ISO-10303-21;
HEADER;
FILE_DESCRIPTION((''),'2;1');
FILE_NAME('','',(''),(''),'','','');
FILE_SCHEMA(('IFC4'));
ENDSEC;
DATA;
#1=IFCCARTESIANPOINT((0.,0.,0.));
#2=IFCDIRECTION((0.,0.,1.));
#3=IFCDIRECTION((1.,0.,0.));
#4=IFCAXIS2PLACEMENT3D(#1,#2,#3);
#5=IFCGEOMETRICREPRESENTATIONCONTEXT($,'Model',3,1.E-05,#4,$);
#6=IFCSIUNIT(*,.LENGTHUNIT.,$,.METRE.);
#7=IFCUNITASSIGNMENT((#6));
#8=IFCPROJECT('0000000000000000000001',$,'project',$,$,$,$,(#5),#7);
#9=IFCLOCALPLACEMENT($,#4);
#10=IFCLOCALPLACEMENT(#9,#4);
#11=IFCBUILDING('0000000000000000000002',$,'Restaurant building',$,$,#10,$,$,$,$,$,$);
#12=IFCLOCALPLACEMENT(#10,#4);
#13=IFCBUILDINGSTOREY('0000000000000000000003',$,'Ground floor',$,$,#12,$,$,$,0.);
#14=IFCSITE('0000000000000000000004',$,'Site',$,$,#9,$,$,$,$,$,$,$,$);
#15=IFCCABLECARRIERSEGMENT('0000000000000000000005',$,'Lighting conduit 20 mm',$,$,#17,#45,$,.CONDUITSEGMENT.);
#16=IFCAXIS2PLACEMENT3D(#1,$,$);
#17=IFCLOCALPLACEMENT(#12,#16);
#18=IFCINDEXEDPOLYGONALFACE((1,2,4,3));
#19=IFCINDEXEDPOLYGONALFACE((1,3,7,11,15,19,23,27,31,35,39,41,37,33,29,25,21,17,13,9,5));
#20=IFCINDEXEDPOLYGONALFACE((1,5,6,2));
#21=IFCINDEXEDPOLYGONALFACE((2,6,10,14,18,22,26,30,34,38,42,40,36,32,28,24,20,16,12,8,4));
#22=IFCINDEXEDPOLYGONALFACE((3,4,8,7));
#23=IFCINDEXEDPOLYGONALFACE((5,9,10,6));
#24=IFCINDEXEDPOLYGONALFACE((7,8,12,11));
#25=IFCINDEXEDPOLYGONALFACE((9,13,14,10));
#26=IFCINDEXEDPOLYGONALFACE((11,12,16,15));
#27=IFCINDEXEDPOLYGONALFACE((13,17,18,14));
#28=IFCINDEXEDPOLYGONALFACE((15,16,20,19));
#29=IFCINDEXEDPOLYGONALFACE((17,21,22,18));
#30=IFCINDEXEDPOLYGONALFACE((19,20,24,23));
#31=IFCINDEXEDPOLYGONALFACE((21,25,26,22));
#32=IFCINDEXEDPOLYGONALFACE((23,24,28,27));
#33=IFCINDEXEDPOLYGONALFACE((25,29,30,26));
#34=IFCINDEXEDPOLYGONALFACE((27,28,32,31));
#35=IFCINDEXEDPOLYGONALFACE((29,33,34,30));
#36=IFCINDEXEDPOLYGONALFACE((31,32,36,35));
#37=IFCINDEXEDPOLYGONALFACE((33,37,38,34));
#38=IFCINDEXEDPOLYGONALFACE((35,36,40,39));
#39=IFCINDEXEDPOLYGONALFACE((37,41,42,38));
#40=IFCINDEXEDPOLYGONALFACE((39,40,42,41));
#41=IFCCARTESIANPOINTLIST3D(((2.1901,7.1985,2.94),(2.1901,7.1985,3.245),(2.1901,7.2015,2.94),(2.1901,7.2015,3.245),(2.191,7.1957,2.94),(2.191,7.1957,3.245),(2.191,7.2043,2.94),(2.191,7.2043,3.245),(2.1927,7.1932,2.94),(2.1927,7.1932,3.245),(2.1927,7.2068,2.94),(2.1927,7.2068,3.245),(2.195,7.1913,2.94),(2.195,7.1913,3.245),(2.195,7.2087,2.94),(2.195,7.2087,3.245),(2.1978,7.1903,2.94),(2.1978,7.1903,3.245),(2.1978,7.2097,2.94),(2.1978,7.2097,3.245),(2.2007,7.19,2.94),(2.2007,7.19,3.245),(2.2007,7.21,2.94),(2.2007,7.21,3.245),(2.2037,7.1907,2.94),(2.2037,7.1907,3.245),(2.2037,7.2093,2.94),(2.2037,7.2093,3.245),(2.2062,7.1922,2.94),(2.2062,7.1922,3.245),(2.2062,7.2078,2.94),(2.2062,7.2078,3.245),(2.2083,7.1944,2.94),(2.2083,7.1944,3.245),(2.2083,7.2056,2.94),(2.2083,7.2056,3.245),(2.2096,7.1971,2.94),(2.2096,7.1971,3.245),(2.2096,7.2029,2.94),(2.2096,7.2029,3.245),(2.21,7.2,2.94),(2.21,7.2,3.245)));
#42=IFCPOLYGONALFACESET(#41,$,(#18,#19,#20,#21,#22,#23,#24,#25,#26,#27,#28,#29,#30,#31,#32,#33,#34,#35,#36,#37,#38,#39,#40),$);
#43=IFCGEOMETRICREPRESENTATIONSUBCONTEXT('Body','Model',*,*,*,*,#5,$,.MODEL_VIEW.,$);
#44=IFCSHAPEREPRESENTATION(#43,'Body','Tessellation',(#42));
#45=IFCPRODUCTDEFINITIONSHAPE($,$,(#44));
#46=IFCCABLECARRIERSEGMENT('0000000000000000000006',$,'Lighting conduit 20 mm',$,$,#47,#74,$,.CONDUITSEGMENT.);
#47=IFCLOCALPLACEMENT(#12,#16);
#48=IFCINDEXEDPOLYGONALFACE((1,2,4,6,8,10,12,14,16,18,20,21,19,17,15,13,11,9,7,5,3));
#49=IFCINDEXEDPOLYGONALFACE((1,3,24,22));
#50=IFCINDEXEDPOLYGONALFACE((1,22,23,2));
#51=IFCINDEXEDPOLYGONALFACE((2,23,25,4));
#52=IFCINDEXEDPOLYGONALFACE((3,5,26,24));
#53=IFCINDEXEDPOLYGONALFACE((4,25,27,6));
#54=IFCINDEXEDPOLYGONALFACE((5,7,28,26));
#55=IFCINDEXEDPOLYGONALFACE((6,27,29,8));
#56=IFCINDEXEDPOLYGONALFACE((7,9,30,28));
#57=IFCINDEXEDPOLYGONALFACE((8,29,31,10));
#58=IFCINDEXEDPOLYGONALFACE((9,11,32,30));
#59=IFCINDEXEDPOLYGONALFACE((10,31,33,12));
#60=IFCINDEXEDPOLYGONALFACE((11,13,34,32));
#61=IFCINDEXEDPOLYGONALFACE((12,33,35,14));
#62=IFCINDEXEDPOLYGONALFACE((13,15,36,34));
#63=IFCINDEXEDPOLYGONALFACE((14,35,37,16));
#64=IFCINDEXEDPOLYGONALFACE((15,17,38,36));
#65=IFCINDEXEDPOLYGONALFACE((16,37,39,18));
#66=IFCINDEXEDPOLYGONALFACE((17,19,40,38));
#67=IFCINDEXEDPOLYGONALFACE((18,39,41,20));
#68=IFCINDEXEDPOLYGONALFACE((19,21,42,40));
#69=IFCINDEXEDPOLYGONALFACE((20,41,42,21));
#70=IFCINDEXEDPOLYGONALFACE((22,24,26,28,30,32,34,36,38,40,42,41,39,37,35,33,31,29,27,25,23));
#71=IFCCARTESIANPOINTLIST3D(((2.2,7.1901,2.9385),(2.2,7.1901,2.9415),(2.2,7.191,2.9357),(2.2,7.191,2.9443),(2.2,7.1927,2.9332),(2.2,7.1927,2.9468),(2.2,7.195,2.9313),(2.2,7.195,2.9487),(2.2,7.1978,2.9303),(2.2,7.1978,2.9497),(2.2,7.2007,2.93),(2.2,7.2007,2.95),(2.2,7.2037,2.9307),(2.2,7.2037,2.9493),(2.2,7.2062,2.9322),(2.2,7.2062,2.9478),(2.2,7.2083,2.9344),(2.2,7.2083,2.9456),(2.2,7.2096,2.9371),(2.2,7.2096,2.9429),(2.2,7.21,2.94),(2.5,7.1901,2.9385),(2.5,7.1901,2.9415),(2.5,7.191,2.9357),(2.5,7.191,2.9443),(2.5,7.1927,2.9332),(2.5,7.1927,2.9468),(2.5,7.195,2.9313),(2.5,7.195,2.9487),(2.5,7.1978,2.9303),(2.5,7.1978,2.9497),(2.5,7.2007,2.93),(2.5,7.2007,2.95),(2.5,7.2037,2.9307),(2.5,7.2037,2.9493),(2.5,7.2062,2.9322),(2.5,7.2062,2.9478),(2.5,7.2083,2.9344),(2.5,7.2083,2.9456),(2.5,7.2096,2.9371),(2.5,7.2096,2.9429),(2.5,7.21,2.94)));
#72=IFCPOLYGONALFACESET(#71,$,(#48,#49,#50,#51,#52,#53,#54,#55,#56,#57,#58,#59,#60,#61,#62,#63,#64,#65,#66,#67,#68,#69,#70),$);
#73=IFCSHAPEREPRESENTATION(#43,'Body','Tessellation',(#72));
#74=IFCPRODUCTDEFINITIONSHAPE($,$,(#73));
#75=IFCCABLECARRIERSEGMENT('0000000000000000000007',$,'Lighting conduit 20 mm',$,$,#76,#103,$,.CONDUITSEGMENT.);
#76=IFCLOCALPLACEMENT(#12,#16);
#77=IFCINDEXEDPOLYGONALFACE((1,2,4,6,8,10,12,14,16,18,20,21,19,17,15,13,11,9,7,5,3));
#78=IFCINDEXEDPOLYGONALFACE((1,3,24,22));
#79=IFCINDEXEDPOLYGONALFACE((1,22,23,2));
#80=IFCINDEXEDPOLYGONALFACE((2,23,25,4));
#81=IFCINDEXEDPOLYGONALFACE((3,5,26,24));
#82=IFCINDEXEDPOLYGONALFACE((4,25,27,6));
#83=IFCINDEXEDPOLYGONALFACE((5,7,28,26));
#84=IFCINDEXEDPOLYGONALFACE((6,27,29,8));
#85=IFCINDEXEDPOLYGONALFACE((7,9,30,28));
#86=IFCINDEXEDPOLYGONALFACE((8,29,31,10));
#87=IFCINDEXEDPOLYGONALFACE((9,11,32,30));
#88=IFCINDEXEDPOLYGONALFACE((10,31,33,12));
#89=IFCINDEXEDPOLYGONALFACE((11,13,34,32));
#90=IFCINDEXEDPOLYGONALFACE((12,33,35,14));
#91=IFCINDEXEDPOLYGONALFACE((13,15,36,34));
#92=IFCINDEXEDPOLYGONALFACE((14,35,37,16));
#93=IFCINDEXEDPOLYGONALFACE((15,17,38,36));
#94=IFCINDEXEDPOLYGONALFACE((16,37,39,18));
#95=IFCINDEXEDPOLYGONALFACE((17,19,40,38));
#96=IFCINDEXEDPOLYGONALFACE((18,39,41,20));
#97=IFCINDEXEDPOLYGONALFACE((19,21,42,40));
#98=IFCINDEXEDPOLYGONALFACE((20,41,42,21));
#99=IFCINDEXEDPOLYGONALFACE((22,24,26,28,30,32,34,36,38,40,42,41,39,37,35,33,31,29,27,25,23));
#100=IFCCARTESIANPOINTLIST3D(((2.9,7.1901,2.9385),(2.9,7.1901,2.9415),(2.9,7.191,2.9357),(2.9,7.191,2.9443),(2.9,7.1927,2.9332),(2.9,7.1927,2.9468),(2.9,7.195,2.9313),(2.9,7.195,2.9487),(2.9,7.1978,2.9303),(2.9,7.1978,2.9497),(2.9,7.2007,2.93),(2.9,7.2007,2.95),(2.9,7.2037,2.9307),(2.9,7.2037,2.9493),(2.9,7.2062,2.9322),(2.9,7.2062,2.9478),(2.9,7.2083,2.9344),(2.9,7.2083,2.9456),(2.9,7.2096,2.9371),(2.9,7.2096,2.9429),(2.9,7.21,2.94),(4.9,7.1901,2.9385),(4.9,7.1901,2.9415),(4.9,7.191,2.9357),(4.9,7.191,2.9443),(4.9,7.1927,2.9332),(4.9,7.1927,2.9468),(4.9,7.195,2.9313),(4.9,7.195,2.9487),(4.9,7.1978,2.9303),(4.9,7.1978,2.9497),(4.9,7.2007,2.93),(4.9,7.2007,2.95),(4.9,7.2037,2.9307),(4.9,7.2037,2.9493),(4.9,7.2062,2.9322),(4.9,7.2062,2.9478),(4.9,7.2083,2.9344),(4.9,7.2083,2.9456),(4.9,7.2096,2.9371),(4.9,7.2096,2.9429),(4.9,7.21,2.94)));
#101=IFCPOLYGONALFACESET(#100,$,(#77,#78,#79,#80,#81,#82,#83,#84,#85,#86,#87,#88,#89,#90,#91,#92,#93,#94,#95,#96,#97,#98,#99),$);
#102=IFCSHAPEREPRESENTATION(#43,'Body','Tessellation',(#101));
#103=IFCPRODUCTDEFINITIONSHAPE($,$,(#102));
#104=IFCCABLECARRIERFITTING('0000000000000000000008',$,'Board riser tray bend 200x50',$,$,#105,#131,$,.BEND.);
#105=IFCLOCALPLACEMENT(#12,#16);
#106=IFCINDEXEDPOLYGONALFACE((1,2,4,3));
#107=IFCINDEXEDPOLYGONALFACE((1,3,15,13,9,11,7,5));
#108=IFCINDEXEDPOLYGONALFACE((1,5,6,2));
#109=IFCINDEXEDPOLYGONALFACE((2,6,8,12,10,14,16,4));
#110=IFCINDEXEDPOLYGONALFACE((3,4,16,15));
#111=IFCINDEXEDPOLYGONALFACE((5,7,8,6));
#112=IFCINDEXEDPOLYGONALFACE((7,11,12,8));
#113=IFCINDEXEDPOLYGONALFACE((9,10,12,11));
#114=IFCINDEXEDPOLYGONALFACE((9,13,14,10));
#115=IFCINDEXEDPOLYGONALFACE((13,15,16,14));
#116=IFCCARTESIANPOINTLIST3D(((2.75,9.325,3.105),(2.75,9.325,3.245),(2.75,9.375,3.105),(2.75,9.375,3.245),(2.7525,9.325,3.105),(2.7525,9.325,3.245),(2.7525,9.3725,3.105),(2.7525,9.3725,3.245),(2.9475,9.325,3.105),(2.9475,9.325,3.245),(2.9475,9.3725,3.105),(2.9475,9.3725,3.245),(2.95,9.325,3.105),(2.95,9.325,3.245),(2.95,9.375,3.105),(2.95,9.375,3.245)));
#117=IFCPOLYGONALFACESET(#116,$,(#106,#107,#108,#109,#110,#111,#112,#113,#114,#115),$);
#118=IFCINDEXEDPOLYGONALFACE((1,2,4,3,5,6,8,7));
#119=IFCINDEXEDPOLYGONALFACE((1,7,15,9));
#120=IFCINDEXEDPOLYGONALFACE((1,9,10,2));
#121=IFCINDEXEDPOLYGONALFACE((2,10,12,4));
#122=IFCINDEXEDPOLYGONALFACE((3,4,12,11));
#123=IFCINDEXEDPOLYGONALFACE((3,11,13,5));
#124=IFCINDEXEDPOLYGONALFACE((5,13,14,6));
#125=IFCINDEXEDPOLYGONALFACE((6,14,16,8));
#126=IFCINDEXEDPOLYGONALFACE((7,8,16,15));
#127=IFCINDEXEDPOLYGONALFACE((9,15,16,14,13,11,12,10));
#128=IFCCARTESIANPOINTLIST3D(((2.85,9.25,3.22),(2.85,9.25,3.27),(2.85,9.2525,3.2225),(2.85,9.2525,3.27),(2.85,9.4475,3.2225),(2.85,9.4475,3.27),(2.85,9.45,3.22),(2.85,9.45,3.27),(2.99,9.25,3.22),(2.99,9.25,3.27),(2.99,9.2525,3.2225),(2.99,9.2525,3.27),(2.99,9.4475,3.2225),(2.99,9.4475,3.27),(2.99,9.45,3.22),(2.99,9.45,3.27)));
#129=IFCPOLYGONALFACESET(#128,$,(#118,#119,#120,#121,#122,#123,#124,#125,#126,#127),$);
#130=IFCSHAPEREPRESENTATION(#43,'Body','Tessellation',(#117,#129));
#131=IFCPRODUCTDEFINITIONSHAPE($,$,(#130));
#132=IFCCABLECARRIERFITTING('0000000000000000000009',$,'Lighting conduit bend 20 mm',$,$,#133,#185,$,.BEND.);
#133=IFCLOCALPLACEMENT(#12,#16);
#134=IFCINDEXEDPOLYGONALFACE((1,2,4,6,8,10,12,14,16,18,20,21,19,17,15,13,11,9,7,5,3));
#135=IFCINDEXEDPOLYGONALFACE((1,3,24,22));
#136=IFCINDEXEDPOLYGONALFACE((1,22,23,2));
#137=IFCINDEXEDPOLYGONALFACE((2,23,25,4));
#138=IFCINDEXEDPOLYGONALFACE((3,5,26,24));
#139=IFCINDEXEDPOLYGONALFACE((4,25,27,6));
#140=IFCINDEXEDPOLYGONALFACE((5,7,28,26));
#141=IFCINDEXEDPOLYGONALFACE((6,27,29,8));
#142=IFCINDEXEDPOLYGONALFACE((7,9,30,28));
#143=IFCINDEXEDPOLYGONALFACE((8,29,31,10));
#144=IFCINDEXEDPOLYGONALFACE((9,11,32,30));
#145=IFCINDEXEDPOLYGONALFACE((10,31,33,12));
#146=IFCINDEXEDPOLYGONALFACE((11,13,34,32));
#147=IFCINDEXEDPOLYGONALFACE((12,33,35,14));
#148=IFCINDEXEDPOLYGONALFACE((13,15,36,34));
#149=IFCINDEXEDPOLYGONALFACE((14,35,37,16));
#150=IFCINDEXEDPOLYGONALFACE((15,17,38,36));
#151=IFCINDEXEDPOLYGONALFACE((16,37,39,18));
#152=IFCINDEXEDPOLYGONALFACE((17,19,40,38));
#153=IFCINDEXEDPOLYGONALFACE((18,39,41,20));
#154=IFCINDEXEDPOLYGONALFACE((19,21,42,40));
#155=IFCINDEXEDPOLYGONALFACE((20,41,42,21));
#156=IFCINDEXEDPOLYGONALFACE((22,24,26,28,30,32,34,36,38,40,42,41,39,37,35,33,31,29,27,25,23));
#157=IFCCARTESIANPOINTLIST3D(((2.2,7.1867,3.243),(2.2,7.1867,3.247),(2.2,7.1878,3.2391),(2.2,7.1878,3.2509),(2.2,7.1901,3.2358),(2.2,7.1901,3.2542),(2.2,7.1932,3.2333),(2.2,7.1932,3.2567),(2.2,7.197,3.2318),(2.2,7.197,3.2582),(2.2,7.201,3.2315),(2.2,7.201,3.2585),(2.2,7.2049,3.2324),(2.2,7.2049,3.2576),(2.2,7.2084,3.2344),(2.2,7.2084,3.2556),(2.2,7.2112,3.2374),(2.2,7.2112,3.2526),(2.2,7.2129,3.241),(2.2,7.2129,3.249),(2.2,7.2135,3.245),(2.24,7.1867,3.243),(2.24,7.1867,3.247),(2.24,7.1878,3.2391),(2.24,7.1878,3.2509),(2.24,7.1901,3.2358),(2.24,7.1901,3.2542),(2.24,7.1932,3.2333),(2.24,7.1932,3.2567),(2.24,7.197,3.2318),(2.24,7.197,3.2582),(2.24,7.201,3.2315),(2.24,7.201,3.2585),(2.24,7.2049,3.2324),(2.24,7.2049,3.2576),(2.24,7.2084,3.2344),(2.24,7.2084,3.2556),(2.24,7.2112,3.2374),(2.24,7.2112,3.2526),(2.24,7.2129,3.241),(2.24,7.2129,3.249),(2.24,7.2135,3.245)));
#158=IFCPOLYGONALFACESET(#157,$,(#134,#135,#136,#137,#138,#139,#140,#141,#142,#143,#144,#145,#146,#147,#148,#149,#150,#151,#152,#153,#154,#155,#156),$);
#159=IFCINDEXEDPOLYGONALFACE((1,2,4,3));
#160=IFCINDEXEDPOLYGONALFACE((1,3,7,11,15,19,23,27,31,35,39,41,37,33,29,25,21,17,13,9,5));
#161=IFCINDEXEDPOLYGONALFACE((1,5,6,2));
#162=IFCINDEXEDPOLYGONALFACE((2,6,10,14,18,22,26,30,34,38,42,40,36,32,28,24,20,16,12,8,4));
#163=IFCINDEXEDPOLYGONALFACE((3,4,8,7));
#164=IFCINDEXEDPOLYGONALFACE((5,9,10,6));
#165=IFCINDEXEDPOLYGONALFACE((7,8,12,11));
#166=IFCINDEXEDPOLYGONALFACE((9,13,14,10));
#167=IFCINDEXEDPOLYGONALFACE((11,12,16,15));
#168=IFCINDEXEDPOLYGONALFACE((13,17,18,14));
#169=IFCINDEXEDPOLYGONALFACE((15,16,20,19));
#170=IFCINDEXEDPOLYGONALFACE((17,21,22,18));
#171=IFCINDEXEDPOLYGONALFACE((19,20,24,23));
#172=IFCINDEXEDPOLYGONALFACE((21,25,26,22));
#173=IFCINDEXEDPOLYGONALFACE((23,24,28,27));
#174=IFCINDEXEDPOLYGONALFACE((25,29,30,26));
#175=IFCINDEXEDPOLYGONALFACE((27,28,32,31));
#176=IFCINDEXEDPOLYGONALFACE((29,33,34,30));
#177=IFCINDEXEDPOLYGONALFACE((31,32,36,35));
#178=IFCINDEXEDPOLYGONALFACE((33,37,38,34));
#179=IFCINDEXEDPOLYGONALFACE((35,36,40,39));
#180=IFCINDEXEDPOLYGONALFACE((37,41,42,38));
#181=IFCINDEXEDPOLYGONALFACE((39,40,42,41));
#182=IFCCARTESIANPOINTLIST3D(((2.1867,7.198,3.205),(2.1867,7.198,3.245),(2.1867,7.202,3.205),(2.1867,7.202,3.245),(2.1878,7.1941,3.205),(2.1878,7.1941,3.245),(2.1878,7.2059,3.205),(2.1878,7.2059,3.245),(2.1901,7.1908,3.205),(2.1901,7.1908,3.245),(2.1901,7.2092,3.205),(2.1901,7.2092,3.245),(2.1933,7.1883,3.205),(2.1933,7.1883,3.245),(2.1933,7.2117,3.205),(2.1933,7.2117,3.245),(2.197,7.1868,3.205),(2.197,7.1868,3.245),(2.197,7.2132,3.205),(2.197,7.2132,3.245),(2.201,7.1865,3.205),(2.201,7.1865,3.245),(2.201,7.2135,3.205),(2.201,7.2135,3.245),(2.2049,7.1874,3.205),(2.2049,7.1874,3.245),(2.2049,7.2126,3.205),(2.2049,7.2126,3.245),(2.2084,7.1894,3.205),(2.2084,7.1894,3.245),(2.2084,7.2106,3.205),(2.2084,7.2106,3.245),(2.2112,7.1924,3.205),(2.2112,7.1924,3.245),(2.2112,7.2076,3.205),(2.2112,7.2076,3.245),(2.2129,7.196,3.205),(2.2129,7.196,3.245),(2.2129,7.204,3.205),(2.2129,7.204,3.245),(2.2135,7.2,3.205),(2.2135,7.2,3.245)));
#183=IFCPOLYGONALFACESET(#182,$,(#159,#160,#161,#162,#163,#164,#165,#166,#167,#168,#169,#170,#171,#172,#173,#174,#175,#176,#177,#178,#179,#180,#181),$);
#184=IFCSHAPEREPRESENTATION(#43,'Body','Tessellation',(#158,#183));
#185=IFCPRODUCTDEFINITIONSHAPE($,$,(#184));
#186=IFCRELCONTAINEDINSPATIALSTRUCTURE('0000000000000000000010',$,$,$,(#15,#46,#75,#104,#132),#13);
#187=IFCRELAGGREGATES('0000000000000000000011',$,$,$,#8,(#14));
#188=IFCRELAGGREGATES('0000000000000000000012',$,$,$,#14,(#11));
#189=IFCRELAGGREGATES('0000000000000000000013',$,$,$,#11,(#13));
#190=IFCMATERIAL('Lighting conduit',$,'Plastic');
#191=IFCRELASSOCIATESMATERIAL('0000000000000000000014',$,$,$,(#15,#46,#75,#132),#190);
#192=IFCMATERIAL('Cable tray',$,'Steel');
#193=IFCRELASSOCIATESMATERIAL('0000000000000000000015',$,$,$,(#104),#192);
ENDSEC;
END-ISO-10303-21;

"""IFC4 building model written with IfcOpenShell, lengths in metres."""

from ifc_helpers import new_model, si_unit, frame, origin_with_axes, origin_2d, place, context, subcontext, project, spatial, polyline, circle, outline, extrude, material, element, save


model = new_model("IFC4")

# Units and contexts
model_context = context("Model", 3, precision=1e-05, world=origin_with_axes())
body_context = subcontext(model_context, "Body", "Model", "MODEL_VIEW")
ifc_project = project(units=[si_unit("LENGTHUNIT", "METRE")], contexts=[model_context])

# Site, building, storey
site_placement = place(None, origin_with_axes())
site = spatial("IfcSite", under=ifc_project, at=site_placement, Name="Site")
building_placement = place(site_placement, origin_with_axes())
building = spatial("IfcBuilding", under=site, at=building_placement, Name="Restaurant building")
storey_placement = place(building_placement, origin_with_axes())
storey = spatial("IfcBuildingStorey", under=building, at=storey_placement, Name="Ground floor", Elevation=0.0)

# Cable carrier segments
ifc_material_1 = material(Name="Cable tray", Category="Steel")
ifc_material_2 = material(Name="Lighting conduit", Category="Plastic")
cable_carrier_segment_1_placement = place(storey_placement, frame((2.2, 7.2, 3.245)))
element("IfcCableCarrierSegment", 1, at=cable_carrier_segment_1_placement, inside=storey, material=ifc_material_2, Name="Lighting conduit 20 mm", PredefinedType="CONDUITSEGMENT", context=body_context, shape_type="SweptSolid", body=[
    extrude(circle(Radius=0.01, at=origin_2d()), frame((0.0, 0.0, 0.0), z_axis=(0.0, 0.0, -1.0), x_axis=(1.0, 0.0, 0.0)), (0.0, 0.0, 1.0), 0.305),
])
cable_carrier_segment_2_placement = place(storey_placement, frame((2.2, 7.2, 2.94)))
element("IfcCableCarrierSegment", 2, at=cable_carrier_segment_2_placement, inside=storey, material=ifc_material_2, Name="Lighting conduit 20 mm", PredefinedType="CONDUITSEGMENT", context=body_context, shape_type="SweptSolid", body=[
    extrude(circle(Radius=0.01, at=origin_2d()), frame((0.0, 0.0, 0.0), z_axis=(1.0, 0.0, 0.0), x_axis=(0.0, 1.0, 0.0)), (0.0, 0.0, 1.0), 0.3),
])
cable_carrier_segment_3_placement = place(storey_placement, frame((2.9, 7.2, 2.94)))
element("IfcCableCarrierSegment", 3, at=cable_carrier_segment_3_placement, inside=storey, material=ifc_material_2, Name="Lighting conduit 20 mm", PredefinedType="CONDUITSEGMENT", context=body_context, shape_type="SweptSolid", body=[
    extrude(circle(Radius=0.01, at=origin_2d()), frame((0.0, 0.0, 0.0), z_axis=(1.0, 0.0, 0.0), x_axis=(0.0, 1.0, 0.0)), (0.0, 0.0, 1.0), 2.0),
])

# Cable carrier fittings
cable_carrier_fitting_1_placement = place(storey_placement, frame((2.85, 9.35, 3.245)))
element("IfcCableCarrierFitting", 4, at=cable_carrier_fitting_1_placement, inside=storey, material=ifc_material_1, Name="Board riser tray bend 200x50", PredefinedType="BEND", context=body_context, shape_type="SweptSolid", body=[
    extrude(outline(polyline([(-0.1, -0.025), (0.1, -0.025), (0.1, 0.025), (0.0975, 0.025), (0.0975, -0.0225), (-0.0975, -0.0225), (-0.0975, 0.025), (-0.1, 0.025), (-0.1, -0.025)])), frame((0.0, 0.0, 0.0), z_axis=(0.0, 0.0, -1.0), x_axis=(1.0, 0.0, 0.0)), (0.0, 0.0, 1.0), 0.14),
    extrude(outline(polyline([(-0.1, -0.025), (0.1, -0.025), (0.1, 0.025), (0.0975, 0.025), (0.0975, -0.0225), (-0.0975, -0.0225), (-0.0975, 0.025), (-0.1, 0.025), (-0.1, -0.025)])), frame((0.0, 0.0, 0.0), z_axis=(1.0, 0.0, 0.0), x_axis=(0.0, 1.0, 0.0)), (0.0, 0.0, 1.0), 0.14),
])
cable_carrier_fitting_2_placement = place(storey_placement, frame((2.2, 7.2, 3.245)))
element("IfcCableCarrierFitting", 5, at=cable_carrier_fitting_2_placement, inside=storey, material=ifc_material_2, Name="Lighting conduit bend 20 mm", PredefinedType="BEND", context=body_context, shape_type="SweptSolid", body=[
    extrude(circle(Radius=0.0135, at=origin_2d()), frame((0.0, 0.0, 0.0), z_axis=(1.0, 0.0, 0.0), x_axis=(0.0, 1.0, 0.0)), (0.0, 0.0, 1.0), 0.04),
    extrude(circle(Radius=0.0135, at=origin_2d()), frame((0.0, 0.0, 0.0), z_axis=(0.0, 0.0, -1.0), x_axis=(1.0, 0.0, 0.0)), (0.0, 0.0, 1.0), 0.04),
])

save(model, "model.ifc")
